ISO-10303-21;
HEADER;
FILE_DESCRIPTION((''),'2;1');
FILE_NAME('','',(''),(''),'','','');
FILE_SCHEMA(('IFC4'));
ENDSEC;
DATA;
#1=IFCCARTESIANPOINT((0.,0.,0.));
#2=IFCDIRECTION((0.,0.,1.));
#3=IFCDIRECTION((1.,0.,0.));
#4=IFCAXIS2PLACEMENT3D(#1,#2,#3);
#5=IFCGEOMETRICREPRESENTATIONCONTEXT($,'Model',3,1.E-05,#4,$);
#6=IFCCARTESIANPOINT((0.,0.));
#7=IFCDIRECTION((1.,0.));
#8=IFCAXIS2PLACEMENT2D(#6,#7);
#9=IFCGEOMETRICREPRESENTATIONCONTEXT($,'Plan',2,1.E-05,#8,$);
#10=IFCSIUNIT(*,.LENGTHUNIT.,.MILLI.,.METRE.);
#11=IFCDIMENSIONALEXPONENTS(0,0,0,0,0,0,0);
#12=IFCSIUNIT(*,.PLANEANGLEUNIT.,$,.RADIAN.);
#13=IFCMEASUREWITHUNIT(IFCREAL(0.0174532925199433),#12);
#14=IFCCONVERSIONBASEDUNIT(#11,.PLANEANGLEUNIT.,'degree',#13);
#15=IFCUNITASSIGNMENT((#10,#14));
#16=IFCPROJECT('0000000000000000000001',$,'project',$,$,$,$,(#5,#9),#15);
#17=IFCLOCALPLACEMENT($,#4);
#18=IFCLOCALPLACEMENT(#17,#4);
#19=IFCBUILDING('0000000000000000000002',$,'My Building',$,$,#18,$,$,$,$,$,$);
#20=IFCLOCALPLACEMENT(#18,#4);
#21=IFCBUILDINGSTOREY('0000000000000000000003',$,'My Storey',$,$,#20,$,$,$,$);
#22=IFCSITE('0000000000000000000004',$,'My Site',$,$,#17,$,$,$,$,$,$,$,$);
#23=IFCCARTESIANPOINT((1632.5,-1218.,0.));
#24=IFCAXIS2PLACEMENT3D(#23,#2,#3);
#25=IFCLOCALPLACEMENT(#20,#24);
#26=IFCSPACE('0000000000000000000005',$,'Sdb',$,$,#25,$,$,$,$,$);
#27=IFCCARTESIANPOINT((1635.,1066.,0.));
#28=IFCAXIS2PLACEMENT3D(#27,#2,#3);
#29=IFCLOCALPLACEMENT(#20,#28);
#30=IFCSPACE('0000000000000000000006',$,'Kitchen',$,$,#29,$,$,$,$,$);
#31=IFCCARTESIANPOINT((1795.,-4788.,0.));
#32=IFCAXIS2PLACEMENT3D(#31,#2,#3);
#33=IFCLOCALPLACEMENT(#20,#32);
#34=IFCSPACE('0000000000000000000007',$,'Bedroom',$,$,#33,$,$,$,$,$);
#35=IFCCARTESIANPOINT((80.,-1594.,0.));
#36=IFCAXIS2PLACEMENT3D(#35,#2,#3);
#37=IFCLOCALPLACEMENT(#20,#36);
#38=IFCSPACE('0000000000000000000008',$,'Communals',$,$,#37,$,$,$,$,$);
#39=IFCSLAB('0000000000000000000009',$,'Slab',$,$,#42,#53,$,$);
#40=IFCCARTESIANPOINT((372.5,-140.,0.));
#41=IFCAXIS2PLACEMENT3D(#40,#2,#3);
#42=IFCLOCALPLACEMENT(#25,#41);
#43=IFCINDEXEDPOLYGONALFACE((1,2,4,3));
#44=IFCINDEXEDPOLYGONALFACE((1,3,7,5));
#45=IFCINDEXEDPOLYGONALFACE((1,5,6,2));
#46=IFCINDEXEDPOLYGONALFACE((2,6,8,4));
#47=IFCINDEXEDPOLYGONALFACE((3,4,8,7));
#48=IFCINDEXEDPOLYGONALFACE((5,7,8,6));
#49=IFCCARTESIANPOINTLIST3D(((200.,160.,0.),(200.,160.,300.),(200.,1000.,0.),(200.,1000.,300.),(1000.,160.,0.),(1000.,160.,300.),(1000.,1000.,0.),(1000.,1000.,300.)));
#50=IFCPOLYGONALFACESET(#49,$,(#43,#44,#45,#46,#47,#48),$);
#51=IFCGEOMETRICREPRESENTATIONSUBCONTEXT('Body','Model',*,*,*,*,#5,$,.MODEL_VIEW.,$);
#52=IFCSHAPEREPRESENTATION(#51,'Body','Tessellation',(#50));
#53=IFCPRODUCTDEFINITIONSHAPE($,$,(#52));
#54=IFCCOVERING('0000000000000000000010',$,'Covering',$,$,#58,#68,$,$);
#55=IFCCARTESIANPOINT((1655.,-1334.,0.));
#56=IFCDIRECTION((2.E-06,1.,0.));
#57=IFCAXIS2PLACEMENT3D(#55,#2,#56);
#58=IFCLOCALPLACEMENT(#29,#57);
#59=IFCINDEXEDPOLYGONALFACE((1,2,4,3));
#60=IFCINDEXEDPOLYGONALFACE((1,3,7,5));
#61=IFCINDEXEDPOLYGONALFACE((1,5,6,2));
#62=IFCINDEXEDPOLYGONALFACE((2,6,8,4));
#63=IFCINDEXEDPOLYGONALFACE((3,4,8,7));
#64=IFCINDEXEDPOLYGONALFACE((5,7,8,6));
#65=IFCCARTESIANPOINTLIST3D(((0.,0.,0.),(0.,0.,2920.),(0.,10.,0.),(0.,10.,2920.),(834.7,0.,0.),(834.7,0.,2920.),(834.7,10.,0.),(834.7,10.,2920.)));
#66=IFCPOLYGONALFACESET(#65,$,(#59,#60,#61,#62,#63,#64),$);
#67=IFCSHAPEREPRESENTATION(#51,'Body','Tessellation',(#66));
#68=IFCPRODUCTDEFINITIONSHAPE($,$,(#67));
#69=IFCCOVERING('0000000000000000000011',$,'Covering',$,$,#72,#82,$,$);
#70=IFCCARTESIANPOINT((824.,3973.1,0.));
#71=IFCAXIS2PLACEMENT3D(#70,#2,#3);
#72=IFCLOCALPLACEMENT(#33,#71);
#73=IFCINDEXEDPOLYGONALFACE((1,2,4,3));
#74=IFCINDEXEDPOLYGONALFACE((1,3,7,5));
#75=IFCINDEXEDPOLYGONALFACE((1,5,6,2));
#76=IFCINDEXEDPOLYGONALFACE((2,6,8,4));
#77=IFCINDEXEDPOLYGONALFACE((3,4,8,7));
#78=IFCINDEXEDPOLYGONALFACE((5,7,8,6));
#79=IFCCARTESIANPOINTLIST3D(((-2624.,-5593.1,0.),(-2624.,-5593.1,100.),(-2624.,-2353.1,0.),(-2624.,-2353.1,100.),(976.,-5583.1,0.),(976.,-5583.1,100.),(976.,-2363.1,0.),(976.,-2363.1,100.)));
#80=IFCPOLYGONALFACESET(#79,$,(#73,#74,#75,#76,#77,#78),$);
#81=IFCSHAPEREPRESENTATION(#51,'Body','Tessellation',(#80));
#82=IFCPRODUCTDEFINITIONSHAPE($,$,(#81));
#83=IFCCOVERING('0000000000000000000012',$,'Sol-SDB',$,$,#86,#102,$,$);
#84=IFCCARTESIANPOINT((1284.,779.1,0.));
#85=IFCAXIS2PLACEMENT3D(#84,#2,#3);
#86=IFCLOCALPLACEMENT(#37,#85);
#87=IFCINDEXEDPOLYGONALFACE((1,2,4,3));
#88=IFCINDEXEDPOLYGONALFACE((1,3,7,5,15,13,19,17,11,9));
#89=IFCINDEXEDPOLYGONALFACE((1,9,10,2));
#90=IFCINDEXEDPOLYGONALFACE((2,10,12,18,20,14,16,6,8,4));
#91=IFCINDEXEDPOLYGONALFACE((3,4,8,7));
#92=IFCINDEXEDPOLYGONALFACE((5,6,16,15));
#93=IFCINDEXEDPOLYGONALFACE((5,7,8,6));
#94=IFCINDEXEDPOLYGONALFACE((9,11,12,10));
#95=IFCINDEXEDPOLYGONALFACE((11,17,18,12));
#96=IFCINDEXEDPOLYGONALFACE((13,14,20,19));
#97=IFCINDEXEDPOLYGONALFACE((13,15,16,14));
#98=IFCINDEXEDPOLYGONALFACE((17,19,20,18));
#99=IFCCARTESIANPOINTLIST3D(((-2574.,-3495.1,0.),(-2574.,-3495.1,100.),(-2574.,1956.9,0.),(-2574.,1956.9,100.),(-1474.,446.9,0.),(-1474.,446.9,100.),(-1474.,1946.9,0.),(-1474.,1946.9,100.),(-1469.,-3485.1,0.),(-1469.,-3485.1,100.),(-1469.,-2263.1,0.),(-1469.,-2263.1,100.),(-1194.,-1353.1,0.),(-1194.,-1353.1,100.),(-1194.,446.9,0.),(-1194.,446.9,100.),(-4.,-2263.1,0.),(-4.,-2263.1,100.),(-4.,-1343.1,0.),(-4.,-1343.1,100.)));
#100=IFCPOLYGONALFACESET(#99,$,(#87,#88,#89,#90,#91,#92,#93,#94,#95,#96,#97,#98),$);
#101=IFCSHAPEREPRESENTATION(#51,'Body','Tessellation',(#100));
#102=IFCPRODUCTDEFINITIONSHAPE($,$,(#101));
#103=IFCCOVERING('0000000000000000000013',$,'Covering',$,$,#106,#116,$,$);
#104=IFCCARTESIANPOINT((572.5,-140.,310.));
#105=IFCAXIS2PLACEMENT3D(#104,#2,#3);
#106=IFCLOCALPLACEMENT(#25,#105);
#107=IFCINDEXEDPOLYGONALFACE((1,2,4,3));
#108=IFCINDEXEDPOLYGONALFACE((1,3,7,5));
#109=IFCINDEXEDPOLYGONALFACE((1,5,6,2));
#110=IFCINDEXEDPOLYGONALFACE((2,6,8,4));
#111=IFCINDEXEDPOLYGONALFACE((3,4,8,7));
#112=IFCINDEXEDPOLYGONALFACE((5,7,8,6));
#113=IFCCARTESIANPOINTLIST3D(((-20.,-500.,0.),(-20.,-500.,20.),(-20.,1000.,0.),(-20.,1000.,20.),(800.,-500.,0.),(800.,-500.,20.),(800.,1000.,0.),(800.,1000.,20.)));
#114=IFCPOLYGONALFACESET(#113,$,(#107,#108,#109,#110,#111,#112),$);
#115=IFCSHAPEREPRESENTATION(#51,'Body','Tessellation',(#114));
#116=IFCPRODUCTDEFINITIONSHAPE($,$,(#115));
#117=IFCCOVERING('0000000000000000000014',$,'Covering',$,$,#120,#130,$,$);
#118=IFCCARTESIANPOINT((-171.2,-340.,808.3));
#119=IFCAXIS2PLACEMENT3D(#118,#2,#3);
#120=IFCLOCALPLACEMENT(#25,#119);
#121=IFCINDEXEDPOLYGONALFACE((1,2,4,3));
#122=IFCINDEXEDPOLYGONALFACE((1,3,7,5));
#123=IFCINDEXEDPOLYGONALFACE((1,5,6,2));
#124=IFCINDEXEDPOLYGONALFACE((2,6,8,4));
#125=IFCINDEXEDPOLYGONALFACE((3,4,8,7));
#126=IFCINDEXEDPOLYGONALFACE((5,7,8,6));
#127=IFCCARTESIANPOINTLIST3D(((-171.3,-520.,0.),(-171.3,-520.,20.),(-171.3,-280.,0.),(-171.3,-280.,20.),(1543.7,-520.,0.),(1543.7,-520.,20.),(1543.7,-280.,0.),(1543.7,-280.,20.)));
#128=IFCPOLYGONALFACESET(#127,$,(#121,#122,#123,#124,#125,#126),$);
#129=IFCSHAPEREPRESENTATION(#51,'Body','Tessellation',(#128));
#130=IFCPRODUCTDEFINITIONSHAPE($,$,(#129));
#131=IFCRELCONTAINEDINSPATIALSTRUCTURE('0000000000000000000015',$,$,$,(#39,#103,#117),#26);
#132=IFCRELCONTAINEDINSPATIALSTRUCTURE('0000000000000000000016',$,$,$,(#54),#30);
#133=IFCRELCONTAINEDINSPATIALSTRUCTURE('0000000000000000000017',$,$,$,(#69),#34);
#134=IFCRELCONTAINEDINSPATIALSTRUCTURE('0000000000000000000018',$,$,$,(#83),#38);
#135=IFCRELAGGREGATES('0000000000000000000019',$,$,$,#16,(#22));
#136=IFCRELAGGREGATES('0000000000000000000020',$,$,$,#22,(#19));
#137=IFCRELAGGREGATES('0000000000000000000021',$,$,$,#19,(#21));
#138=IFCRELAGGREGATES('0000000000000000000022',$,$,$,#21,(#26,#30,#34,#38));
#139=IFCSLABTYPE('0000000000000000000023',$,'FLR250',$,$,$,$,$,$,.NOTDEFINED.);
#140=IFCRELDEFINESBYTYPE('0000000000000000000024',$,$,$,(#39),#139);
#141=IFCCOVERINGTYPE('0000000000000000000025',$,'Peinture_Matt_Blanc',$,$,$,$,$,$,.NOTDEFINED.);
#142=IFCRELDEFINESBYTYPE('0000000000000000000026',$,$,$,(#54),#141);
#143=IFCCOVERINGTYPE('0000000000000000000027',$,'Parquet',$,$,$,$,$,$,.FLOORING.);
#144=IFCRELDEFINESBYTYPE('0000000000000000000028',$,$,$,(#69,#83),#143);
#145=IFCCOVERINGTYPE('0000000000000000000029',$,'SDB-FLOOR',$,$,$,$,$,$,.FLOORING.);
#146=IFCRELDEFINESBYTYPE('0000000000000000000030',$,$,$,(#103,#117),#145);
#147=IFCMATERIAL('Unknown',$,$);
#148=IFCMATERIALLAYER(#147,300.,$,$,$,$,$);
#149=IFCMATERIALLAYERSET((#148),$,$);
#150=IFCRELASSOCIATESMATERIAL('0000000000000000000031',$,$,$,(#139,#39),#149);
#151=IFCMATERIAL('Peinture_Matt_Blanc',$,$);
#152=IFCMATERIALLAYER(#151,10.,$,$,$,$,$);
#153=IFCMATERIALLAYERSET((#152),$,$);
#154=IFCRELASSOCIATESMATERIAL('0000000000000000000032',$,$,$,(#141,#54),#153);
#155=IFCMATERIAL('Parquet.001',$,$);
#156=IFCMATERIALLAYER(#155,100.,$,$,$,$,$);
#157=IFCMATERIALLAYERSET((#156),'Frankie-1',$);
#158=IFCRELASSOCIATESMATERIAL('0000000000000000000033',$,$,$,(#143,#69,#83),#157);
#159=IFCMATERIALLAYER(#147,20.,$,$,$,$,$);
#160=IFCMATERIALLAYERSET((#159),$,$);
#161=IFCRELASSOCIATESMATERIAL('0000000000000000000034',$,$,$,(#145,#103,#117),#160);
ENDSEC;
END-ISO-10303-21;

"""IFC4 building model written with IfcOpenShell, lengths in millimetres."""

from ifc_helpers import new_model, entity, si_unit, converted_unit, frame, origin_with_axes, origin_2d_with_axis, place, context, subcontext, project, spatial, line, indexed_curve, outline, extrude, clip, halfspace, material, layer, layer_set, layer_usage, type_object, element, save


model = new_model("IFC4")

# Units and contexts
model_context = context("Model", 3, precision=1e-05, world=origin_with_axes())
plan_context = context("Plan", 2, precision=1e-05, world=origin_2d_with_axis())
body_context = subcontext(model_context, "Body", "Model", "MODEL_VIEW")
ifc_project = project(units=[si_unit("LENGTHUNIT", "METRE", prefix="MILLI"), converted_unit("PLANEANGLEUNIT", "degree", entity("IfcReal", 0.0174532925199433), si_unit("PLANEANGLEUNIT", "RADIAN"), dimensions=[0, 0, 0, 0, 0, 0, 0])], contexts=[model_context, plan_context])

# Site, building, storey, space
site_placement = place(None, origin_with_axes())
site = spatial("IfcSite", under=ifc_project, at=site_placement, Name="My Site")
building_placement = place(site_placement, origin_with_axes())
building = spatial("IfcBuilding", under=site, at=building_placement, Name="My Building")
storey_placement = place(building_placement, origin_with_axes())
storey = spatial("IfcBuildingStorey", under=building, at=storey_placement, Name="My Storey")
space_1_placement = place(storey_placement, frame((1632.5, -1218.0, 0.0), z_axis=(0.0, 0.0, 1.0), x_axis=(1.0, 0.0, 0.0)))
space_1 = spatial("IfcSpace", under=storey, at=space_1_placement, Name="Sdb")

# Slab
ifc_material_1 = material(Name="Unknown")
ifc_layer_1 = layer(ifc_material_1, 300.0)
ifc_layer_set_1 = layer_set([ifc_layer_1])
ifc_layer_usage_1 = layer_usage(ifc_layer_set_1, "AXIS3", "POSITIVE", 0.0)
slab_type = type_object("IfcSlabType", Name="FLR250", PredefinedType="NOTDEFINED", material=ifc_layer_set_1)
slab_placement = place(space_1_placement, frame((372.5, -140.0, 0.0), z_axis=(0.0, 0.0, 1.0), x_axis=(1.0, 0.0, 0.0)))
element("IfcSlab", 1, at=slab_placement, inside=space_1, type_object=slab_type, material=ifc_layer_usage_1, Name="Slab", context=body_context, shape_type="SweptSolid", body=[
    extrude(outline(indexed_curve([(200.0, 1000.0), (200.0, 160.0), (1000.0, 160.0), (1000.0, 1000.0)], segments=[line(3, 2), line(2, 1), line(1, 4), line(4, 3)], self_intersect=False)), None, (0.0, 0.0, 1.0), 300.0),
])

# Shared definitions
space_2_placement = place(storey_placement, frame((1635.0, 1066.0, 0.0), z_axis=(0.0, 0.0, 1.0), x_axis=(1.0, 0.0, 0.0)))
space_2 = spatial("IfcSpace", under=storey, at=space_2_placement, Name="Kitchen")

# Covering
ifc_material_2 = material(Name="Peinture_Matt_Blanc")
ifc_layer_2 = layer(ifc_material_2, 10.0)
ifc_layer_set_2 = layer_set([ifc_layer_2])
ifc_layer_usage_2 = layer_usage(ifc_layer_set_2, "AXIS2", "POSITIVE", 0.0)
covering_type_1 = type_object("IfcCoveringType", Name="Peinture_Matt_Blanc", PredefinedType="NOTDEFINED", material=ifc_layer_set_2)
covering_1_placement = place(space_2_placement, frame((1655.0, -1334.0, 0.0), z_axis=(0.0, 0.0, 1.0), x_axis=(0.000002, 1.0, 0.0)))
element("IfcCovering", 2, at=covering_1_placement, inside=space_2, type_object=covering_type_1, material=ifc_layer_usage_2, Name="Covering", context=body_context, shape_type="Clipping", body=[
    clip(extrude(outline(indexed_curve([(0.0, 0.0), (0.0, 10.0), (834.7, 10.0), (834.7, 0.0), (0.0, 0.0)], self_intersect=False)), origin_with_axes(), (0.0, 0.0, 1.0), 2920.0), halfspace(frame((0.0, 0.0, 2920.0), z_axis=(0.0, 0.0, 1.0), x_axis=(-1.0, 0.0, 0.0)), False)),
])

# Shared definitions
space_3_placement = place(storey_placement, frame((1795.0, -4788.0, 0.0), z_axis=(0.0, 0.0, 1.0), x_axis=(1.0, 0.0, 0.0)))
space_3 = spatial("IfcSpace", under=storey, at=space_3_placement, Name="Bedroom")

# Covering
ifc_material_3 = material(Name="Parquet.001")
ifc_layer_3 = layer(ifc_material_3, 100.0)
ifc_layer_set_3 = layer_set([ifc_layer_3], Name="Frankie-1")
ifc_layer_usage_3 = layer_usage(ifc_layer_set_3, "AXIS3", "POSITIVE", 0.0)
covering_type_2 = type_object("IfcCoveringType", Name="Parquet", PredefinedType="FLOORING", material=ifc_layer_set_3)
covering_2_placement = place(space_3_placement, frame((824.0, 3973.1, 0.0), z_axis=(0.0, 0.0, 1.0), x_axis=(1.0, 0.0, 0.0)))
element("IfcCovering", 3, at=covering_2_placement, inside=space_3, type_object=covering_type_2, material=ifc_layer_usage_3, Name="Covering", context=body_context, shape_type="SweptSolid", body=[
    extrude(outline(indexed_curve([(976.0, -5583.1), (-2624.0, -5593.1), (-2624.0, -2353.1), (976.0, -2363.1)], segments=[line(3, 2), line(2, 1), line(1, 4), line(4, 3)], self_intersect=False)), None, (0.0, 0.0, 1.0), 100.0),
])

# Shared definitions
space_4_placement = place(storey_placement, frame((80.0, -1594.0, 0.0), z_axis=(0.0, 0.0, 1.0), x_axis=(1.0, 0.0, 0.0)))
space_4 = spatial("IfcSpace", under=storey, at=space_4_placement, Name="Communals")

# Coverings
ifc_layer_usage_4 = layer_usage(ifc_layer_set_3, "AXIS3", "POSITIVE", 0.0)
covering_3_placement = place(space_4_placement, frame((1284.0, 779.1, 0.0), z_axis=(0.0, 0.0, 1.0), x_axis=(1.0, 0.0, 0.0)))
element("IfcCovering", 4, at=covering_3_placement, inside=space_4, type_object=covering_type_2, material=ifc_layer_usage_4, Name="Sol-SDB", context=body_context, shape_type="SweptSolid", body=[
    extrude(outline(indexed_curve([(-2574.0, 1956.9), (-2574.0, -3495.1), (-1469.0, -3485.1), (-1474.0, 1946.9), (-1469.0, -2263.1), (-4.0, -2263.1), (-4.0, -1343.1), (-1194.0, -1353.1), (-1194.0, 446.9), (-1474.0, 446.9)], segments=[line(9, 8), line(8, 7), line(7, 6), line(6, 5), line(5, 3), line(3, 2), line(2, 1), line(1, 4), line(4, 10), line(10, 9)], self_intersect=False)), None, (0.0, 0.0, 1.0), 100.0),
])
ifc_layer_4 = layer(ifc_material_1, 20.0)
ifc_layer_set_4 = layer_set([ifc_layer_4])
ifc_layer_usage_5 = layer_usage(ifc_layer_set_4, "AXIS3", "POSITIVE", 0.0)
covering_type_3 = type_object("IfcCoveringType", Name="SDB-FLOOR", PredefinedType="FLOORING", material=ifc_layer_set_4)
covering_4_placement = place(space_1_placement, frame((572.5, -140.0, 310.0), z_axis=(0.0, 0.0, 1.0), x_axis=(1.0, 0.0, 0.0)))
element("IfcCovering", 5, at=covering_4_placement, inside=space_1, type_object=covering_type_3, material=ifc_layer_usage_5, Name="Covering", context=body_context, shape_type="SweptSolid", body=[
    extrude(outline(indexed_curve([(-20.0, 1000.0), (-20.0, -500.0), (800.0, -500.0), (800.0, 1000.0)], segments=[line(3, 2), line(2, 1), line(1, 4), line(4, 3)], self_intersect=False)), None, (0.0, 0.0, 1.0), 20.0),
])
ifc_layer_usage_6 = layer_usage(ifc_layer_set_4, "AXIS3", "POSITIVE", 0.0)
covering_5_placement = place(space_1_placement, frame((-171.2, -340.0, 808.3), z_axis=(0.0, 0.0, 1.0), x_axis=(1.0, 0.0, 0.0)))
element("IfcCovering", 6, at=covering_5_placement, inside=space_1, type_object=covering_type_3, material=ifc_layer_usage_6, Name="Covering", context=body_context, shape_type="SweptSolid", body=[
    extrude(outline(indexed_curve([(1543.7, -280.0), (-171.3, -280.0), (-171.3, -520.0), (1543.7, -520.0)], segments=[line(4, 1), line(1, 2), line(2, 3), line(3, 4)], self_intersect=False)), None, (0.0, 0.0, 1.0), 20.0),
])

save(model, "model.ifc")
